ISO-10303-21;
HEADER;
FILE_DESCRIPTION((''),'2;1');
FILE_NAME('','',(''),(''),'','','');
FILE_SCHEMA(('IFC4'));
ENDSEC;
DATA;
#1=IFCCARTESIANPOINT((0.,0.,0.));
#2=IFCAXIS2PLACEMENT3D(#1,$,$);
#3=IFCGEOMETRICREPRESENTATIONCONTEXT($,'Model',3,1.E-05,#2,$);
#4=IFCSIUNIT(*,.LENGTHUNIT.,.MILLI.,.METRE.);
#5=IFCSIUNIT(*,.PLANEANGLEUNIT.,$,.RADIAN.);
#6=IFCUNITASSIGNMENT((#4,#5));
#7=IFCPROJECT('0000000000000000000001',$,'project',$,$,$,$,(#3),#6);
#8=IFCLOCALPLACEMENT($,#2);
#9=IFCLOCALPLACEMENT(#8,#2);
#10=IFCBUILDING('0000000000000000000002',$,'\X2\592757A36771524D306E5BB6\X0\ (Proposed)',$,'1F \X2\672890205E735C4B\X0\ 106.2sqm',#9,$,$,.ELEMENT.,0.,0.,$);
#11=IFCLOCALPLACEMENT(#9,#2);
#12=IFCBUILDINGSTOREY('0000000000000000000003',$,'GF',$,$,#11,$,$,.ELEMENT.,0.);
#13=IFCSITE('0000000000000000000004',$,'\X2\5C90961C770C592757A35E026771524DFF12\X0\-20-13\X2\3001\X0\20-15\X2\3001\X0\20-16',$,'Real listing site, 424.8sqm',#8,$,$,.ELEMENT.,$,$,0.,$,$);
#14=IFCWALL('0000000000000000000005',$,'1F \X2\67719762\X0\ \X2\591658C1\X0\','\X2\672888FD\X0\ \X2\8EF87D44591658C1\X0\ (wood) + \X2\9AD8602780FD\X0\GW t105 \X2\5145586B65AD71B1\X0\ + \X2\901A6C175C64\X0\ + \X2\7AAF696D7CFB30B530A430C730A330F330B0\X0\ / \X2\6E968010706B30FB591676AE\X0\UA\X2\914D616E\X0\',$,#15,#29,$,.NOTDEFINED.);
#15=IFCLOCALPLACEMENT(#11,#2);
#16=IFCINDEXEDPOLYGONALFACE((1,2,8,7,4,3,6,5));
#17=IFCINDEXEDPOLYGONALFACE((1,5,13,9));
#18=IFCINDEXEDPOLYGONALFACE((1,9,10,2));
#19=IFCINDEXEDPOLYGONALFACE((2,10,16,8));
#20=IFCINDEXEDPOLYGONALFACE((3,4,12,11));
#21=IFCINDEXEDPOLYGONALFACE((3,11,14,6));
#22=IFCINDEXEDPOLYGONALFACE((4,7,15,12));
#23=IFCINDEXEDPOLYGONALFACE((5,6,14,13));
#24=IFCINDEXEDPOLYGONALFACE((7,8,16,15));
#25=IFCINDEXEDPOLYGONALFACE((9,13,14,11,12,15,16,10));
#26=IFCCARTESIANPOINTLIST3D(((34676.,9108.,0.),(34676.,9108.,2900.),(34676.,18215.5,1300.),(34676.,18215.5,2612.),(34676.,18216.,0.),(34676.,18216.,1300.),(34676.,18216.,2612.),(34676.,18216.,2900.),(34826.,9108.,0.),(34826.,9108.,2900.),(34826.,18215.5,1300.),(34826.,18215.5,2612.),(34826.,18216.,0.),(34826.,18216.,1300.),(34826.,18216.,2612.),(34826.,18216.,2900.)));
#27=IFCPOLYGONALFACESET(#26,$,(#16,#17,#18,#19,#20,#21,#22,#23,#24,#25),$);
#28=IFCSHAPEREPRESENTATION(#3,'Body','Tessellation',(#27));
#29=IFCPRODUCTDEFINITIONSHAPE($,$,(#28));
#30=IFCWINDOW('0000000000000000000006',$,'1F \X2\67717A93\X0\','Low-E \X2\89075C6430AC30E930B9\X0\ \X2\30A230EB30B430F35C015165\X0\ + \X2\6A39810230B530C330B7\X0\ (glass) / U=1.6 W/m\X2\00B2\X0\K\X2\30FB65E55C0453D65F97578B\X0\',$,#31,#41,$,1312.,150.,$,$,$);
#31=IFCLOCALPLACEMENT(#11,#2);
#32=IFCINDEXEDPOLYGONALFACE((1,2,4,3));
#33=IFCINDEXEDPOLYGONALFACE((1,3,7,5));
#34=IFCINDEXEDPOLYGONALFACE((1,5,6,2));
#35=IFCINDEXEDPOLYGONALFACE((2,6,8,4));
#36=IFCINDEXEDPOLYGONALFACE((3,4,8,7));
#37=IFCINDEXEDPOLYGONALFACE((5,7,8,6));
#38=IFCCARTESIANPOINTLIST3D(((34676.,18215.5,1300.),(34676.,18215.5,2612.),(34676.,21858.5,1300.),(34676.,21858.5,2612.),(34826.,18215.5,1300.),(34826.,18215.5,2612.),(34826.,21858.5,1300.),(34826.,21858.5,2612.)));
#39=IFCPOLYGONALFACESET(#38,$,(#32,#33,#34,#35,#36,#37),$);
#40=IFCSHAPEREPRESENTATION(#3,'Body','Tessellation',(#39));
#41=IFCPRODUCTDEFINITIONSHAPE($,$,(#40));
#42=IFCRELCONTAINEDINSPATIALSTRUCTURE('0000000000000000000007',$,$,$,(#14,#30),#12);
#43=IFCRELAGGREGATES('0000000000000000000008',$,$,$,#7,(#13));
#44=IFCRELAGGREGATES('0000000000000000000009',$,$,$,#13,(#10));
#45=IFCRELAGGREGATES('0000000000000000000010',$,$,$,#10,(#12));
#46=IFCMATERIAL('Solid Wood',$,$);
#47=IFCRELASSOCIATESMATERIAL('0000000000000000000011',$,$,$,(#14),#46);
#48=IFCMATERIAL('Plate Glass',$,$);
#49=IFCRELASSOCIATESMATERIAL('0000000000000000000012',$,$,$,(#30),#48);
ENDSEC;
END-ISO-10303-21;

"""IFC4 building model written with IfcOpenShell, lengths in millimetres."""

from ifc_helpers import new_model, si_unit, frame, frame_2d, origin, place, context, project, spatial, rectangle, extrude, material, element, fill, save


model = new_model("IFC4")

# Units and contexts
model_context = context("Model", 3, precision=1e-05, world=origin())
ifc_project = project(units=[si_unit("LENGTHUNIT", "METRE", prefix="MILLI"), si_unit("PLANEANGLEUNIT", "RADIAN")], contexts=[model_context])

# Site, building, storey
site_placement = place(None, origin())
site = spatial("IfcSite", under=ifc_project, at=site_placement, Name="岐阜県大垣市東前２-20-13、20-15、20-16", ObjectType="Real listing site, 424.8sqm", CompositionType="ELEMENT", RefElevation=0.0)
building_placement = place(site_placement, origin())
building = spatial("IfcBuilding", under=site, at=building_placement, Name="大垣東前の家 (Proposed)", ObjectType="1F 木造平屋 106.2sqm", CompositionType="ELEMENT", ElevationOfRefHeight=0.0, ElevationOfTerrain=0.0)
storey_placement = place(building_placement, origin())
storey = spatial("IfcBuildingStorey", under=building, at=storey_placement, Name="GF", CompositionType="ELEMENT", Elevation=0.0)

# Wall, opening, window
ifc_material_1 = material(Name="Solid Wood")
wall_1_placement = place(storey_placement, frame((17338.0, 4554.0, 0.0)))
wall_1 = element("IfcWall", 1, at=wall_1_placement, inside=storey, material=ifc_material_1, Name="1F 東面 外壁", Description="木製 軸組外壁 (wood) + 高性能GW t105 充填断熱 + 通気層 + 窯業系サイディング / 準耐火・外皮UA配慮", PredefinedType="NOTDEFINED", context=model_context, shape_type="SweptSolid", body=[
    extrude(rectangle(XDim=150.0, YDim=9108.0, at=frame_2d((75.0, 4554.0))), frame((17338.0, 4554.0, 0.0)), (0.0, 0.0, 1.0), 2900.0),
])
opening_placement = place(storey_placement, frame((17338.0, 9108.0, 650.0)))
opening = element("IfcOpeningElement", 2, at=opening_placement, cuts=wall_1, PredefinedType="NOTDEFINED", context=model_context, shape_type="SweptSolid", body=[
    extrude(rectangle(XDim=150.0, YDim=3643.0, at=frame_2d((75.0, 1821.0))), frame((17338.0, 9108.0, 650.0)), (0.0, 0.0, 1.0), 1312.0),
])
ifc_material_2 = material(Name="Plate Glass")
window_1_placement = place(storey_placement, frame((17338.0, 9108.0, 650.0)))
window_1 = element("IfcWindow", 3, at=window_1_placement, inside=storey, material=ifc_material_2, Name="1F 東窓", Description="Low-E 複層ガラス アルゴン封入 + 樹脂サッシ (glass) / U=1.6 W/m²K・日射取得型", OverallHeight=1312.0, OverallWidth=150.0, context=model_context, shape_type="SweptSolid", body=[
    extrude(rectangle(XDim=150.0, YDim=3643.0, at=frame_2d((75.0, 1821.0))), frame((17338.0, 9108.0, 650.0)), (0.0, 0.0, 1.0), 1312.0),
])
fill(opening, window_1)

save(model, "model.ifc")
